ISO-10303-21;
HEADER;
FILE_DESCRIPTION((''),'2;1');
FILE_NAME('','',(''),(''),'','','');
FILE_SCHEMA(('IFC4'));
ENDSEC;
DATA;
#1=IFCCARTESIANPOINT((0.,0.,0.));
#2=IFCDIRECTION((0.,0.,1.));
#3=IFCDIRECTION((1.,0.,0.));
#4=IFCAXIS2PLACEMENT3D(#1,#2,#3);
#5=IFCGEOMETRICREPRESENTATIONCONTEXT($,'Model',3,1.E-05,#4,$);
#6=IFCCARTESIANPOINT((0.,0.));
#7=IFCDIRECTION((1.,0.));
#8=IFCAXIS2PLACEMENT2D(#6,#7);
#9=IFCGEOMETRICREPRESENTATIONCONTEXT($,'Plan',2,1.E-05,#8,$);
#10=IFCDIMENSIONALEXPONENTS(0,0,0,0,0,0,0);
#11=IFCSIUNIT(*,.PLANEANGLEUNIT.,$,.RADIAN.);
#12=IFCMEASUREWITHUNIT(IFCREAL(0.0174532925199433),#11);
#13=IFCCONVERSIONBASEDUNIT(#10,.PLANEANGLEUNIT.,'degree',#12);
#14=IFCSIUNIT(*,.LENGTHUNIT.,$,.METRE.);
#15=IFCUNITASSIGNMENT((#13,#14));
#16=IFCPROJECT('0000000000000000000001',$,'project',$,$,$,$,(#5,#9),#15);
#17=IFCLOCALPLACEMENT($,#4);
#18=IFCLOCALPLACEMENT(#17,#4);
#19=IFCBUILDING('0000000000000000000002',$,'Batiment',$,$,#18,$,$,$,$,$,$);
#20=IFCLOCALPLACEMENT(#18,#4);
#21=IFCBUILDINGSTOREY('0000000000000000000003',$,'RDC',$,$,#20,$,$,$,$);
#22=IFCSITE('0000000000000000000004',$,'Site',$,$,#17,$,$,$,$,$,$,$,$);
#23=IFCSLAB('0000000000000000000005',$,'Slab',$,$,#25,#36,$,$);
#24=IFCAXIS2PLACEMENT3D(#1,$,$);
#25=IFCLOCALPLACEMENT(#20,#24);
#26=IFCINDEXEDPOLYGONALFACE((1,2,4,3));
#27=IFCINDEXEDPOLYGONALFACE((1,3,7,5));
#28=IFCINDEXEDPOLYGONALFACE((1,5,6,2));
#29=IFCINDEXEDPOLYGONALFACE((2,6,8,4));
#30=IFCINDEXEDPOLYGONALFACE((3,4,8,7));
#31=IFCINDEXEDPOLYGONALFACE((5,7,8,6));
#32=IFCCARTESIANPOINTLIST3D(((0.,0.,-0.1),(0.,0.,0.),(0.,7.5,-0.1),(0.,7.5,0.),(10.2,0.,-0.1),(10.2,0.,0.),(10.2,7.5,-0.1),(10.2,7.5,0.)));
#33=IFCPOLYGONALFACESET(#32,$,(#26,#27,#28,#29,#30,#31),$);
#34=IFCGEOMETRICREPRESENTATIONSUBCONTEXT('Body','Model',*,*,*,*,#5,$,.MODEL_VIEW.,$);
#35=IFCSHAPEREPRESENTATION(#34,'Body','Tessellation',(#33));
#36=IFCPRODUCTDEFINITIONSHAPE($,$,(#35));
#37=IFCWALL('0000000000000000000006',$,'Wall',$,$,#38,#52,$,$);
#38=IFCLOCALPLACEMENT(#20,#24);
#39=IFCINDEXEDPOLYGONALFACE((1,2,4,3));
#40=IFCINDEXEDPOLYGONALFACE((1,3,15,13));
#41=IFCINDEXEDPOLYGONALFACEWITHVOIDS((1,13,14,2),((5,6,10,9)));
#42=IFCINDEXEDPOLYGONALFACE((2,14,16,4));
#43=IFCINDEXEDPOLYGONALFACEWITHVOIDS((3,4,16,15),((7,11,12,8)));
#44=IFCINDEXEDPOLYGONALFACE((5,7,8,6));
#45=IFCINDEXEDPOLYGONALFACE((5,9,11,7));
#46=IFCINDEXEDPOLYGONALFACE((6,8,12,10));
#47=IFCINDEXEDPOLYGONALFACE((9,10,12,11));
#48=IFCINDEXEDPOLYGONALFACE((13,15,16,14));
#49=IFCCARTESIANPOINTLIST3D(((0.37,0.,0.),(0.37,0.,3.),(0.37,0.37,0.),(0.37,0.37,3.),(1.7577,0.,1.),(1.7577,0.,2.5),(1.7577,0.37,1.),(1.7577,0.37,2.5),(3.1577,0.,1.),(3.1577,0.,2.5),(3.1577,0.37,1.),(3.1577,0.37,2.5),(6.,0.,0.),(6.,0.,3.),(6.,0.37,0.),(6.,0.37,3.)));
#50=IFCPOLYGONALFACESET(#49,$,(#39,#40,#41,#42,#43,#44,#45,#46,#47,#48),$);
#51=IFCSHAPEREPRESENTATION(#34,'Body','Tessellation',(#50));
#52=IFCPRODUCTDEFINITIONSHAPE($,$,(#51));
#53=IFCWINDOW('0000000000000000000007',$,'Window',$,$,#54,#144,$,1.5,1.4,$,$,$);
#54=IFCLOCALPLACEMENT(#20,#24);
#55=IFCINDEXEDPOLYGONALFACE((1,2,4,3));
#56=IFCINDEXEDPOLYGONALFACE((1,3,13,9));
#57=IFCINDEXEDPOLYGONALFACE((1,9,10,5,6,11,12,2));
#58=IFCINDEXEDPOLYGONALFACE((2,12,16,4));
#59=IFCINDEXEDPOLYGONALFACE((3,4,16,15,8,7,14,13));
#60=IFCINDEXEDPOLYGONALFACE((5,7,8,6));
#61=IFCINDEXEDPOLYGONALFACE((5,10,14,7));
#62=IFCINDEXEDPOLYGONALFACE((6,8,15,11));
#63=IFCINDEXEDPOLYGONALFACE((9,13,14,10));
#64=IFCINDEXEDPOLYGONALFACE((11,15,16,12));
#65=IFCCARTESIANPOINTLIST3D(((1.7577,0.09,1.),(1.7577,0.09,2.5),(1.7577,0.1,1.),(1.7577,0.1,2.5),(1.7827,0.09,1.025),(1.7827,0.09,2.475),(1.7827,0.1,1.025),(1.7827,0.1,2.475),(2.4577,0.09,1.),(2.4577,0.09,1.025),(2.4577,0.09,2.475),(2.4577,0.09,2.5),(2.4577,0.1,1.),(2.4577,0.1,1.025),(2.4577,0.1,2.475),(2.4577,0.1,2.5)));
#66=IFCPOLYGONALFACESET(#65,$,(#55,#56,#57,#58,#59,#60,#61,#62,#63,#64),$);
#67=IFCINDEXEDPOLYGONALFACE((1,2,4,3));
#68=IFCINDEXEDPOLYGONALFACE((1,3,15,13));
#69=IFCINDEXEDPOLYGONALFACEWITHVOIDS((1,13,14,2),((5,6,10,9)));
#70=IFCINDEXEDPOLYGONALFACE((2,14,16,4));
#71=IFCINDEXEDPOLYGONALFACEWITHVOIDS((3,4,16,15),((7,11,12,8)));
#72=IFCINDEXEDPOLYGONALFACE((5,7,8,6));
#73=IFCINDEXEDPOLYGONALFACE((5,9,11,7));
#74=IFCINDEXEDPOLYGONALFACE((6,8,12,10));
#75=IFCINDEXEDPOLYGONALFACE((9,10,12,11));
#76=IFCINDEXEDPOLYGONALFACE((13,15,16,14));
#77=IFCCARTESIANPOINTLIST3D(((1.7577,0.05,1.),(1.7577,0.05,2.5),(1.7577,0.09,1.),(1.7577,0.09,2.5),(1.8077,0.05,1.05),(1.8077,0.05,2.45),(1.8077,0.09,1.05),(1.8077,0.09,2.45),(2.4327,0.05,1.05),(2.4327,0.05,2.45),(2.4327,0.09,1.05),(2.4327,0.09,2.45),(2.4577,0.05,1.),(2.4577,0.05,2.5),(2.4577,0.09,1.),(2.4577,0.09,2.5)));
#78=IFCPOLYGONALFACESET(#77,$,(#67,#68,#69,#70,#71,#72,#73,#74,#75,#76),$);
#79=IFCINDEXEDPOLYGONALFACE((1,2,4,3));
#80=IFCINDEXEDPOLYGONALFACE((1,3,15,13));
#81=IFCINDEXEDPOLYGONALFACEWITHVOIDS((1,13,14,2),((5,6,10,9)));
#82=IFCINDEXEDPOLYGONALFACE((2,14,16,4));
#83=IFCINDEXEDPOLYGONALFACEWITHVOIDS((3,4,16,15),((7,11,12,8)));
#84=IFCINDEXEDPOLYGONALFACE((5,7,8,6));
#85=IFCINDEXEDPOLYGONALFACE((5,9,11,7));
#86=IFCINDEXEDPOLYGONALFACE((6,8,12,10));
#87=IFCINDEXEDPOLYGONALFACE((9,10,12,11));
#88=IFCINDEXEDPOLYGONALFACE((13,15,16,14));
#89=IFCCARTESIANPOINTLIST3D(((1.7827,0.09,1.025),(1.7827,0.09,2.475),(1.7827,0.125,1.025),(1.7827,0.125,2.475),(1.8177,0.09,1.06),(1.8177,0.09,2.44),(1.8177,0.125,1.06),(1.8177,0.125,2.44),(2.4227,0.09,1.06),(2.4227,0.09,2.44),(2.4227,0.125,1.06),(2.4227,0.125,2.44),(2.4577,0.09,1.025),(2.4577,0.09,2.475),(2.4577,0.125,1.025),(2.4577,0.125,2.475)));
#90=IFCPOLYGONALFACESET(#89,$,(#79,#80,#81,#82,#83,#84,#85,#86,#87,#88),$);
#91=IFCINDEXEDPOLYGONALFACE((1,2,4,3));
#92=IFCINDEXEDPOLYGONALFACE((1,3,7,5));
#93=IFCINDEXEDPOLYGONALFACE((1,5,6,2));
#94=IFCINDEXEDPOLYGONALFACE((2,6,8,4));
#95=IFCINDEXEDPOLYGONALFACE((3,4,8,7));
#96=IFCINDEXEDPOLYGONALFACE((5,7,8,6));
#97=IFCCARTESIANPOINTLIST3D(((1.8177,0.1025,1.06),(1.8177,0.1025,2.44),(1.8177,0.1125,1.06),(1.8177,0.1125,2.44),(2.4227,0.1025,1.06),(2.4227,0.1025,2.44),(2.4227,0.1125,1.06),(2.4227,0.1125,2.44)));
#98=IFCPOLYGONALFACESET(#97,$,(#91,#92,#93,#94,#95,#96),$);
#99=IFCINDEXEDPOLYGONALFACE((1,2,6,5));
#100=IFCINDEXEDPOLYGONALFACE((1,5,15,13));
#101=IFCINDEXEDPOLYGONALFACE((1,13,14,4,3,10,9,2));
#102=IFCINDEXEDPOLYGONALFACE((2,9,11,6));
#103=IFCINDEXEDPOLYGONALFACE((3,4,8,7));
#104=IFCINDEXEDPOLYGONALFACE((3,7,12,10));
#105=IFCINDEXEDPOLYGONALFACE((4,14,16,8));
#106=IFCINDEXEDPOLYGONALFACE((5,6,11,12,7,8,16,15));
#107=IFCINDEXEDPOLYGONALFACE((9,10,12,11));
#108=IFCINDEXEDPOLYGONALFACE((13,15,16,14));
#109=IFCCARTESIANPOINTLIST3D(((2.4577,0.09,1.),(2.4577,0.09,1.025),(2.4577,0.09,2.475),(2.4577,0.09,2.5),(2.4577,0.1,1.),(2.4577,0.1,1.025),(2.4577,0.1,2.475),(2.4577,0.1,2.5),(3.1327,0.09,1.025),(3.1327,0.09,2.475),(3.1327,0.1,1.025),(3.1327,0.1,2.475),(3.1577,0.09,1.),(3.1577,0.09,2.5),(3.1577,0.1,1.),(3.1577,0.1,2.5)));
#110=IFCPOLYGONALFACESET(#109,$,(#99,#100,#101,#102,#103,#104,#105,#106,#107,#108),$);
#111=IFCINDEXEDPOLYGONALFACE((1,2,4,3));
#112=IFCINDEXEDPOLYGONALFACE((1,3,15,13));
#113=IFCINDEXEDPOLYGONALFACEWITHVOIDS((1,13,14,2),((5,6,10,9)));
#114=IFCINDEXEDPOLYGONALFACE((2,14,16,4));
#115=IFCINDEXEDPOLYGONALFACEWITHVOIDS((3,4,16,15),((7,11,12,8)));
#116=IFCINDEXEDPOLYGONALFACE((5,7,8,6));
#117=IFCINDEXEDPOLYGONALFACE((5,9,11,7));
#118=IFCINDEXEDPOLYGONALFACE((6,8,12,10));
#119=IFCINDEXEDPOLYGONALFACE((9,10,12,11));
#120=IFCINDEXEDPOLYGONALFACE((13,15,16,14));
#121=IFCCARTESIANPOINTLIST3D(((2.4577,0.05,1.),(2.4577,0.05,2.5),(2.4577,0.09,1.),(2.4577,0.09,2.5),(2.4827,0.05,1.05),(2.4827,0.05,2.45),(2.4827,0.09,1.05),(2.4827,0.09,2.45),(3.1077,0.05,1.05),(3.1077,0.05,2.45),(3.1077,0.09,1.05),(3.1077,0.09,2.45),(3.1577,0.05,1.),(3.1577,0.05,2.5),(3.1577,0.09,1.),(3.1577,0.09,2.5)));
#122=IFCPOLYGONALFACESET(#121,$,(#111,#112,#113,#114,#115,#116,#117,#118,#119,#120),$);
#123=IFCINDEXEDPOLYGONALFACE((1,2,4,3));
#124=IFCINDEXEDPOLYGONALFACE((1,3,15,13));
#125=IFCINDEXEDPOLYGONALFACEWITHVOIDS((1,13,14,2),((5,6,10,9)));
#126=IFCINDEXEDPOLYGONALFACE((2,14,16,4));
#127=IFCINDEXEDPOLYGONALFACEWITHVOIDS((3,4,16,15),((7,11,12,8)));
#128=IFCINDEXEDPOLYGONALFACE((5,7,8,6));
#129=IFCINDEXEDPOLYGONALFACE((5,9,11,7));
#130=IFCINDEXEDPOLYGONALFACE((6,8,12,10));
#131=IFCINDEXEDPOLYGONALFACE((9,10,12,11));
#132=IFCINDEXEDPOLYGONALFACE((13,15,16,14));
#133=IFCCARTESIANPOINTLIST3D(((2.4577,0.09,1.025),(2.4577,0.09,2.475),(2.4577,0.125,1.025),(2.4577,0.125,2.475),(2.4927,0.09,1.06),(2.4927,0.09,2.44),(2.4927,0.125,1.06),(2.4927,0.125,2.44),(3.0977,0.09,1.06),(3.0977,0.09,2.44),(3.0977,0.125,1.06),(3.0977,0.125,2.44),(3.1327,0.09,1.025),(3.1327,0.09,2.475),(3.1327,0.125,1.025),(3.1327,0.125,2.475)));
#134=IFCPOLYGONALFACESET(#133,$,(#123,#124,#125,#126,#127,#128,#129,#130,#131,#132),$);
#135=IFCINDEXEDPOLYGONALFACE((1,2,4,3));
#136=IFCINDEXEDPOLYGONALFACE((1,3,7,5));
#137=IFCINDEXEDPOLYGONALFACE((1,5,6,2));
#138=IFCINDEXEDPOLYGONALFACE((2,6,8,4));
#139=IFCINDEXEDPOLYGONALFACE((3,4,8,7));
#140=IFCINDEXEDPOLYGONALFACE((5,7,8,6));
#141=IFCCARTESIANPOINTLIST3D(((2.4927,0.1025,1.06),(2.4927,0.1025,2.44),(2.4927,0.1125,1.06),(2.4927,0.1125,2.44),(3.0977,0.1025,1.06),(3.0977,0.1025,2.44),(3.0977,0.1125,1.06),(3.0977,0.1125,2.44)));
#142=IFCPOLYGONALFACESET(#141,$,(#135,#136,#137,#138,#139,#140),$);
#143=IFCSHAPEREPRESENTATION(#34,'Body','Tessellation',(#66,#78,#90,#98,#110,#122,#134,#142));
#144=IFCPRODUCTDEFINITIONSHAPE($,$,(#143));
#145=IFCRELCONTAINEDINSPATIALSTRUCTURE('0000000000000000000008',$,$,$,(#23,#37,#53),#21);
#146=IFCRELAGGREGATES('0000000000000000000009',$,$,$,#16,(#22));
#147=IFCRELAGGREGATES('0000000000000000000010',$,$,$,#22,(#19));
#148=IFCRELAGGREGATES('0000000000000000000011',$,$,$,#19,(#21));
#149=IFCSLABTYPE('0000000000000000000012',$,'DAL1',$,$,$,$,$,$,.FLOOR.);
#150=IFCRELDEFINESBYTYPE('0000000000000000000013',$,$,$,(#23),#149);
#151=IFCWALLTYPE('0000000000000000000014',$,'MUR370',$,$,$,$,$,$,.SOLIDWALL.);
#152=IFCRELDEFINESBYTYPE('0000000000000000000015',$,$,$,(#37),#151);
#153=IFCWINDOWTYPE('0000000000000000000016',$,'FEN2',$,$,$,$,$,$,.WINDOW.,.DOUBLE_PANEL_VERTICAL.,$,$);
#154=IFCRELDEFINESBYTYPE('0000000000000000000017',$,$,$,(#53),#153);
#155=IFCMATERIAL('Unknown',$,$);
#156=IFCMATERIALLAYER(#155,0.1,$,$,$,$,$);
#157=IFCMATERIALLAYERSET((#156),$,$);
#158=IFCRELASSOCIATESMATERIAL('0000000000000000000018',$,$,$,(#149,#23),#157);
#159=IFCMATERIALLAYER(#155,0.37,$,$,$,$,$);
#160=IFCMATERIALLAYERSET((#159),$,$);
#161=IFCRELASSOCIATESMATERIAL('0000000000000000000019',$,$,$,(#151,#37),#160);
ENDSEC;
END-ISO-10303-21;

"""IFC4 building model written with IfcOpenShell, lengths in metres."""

from ifc_helpers import new_model, entity, si_unit, converted_unit, frame, origin_with_axes, origin_2d_with_axis, place, context, subcontext, project, spatial, line, indexed_curve, outline, extrude, shape, source, transform, mapped, material, layer, layer_set, layer_usage, type_object, type_shapes, element, fill, save


model = new_model("IFC4")

# Units and contexts
model_context = context("Model", 3, precision=1e-05, world=origin_with_axes())
plan_context = context("Plan", 2, precision=1e-05, world=origin_2d_with_axis())
body_context_1 = subcontext(model_context, "Body", "Model", "MODEL_VIEW")
body_context_2 = subcontext(plan_context, "Body", "Plan", "PLAN_VIEW")
ifc_project = project(units=[converted_unit("PLANEANGLEUNIT", "degree", entity("IfcReal", 0.0174532925199433), si_unit("PLANEANGLEUNIT", "RADIAN"), dimensions=[0, 0, 0, 0, 0, 0, 0]), si_unit("LENGTHUNIT", "METRE")], contexts=[model_context, plan_context])

# Site, building, storey
site_placement = place(None, origin_with_axes())
site = spatial("IfcSite", under=ifc_project, at=site_placement, Name="Site")
building_placement = place(site_placement, origin_with_axes())
building = spatial("IfcBuilding", under=site, at=building_placement, Name="Batiment")
storey_placement = place(building_placement, origin_with_axes())
storey = spatial("IfcBuildingStorey", under=building, at=storey_placement, Name="RDC")

# Slab
ifc_material = material(Name="Unknown")
ifc_layer_1 = layer(ifc_material, 0.1)
ifc_layer_set_1 = layer_set([ifc_layer_1])
ifc_layer_usage_1 = layer_usage(ifc_layer_set_1, "AXIS3", "POSITIVE", 0.0)
slab_type = type_object("IfcSlabType", Name="DAL1", PredefinedType="FLOOR", material=ifc_layer_set_1)
slab_placement = place(storey_placement, frame((0.0, 0.0, -0.1), z_axis=(0.0, 0.0, 1.0), x_axis=(1.0, 0.0, 0.0)))
element("IfcSlab", 1, at=slab_placement, inside=storey, type_object=slab_type, material=ifc_layer_usage_1, Name="Slab", context=body_context_1, shape_type="SweptSolid", body=[
    extrude(outline(indexed_curve([(0.0, 0.0), (10.2, 0.0), (10.2, 7.5), (0.0, 7.5)], segments=[line(4, 1), line(1, 2), line(2, 3), line(3, 4)], self_intersect=False)), None, (0.0, 0.0, 1.0), 0.1),
])

# Wall, opening, window
ifc_layer_2 = layer(ifc_material, 0.37)
ifc_layer_set_2 = layer_set([ifc_layer_2])
ifc_layer_usage_2 = layer_usage(ifc_layer_set_2, "AXIS2", "POSITIVE", 0.0)
wall_type_1 = type_object("IfcWallType", Name="MUR370", PredefinedType="SOLIDWALL", material=ifc_layer_set_2)
wall_1_placement = place(storey_placement, frame((0.37, 0.0, 0.0), z_axis=(0.0, 0.0, 1.0), x_axis=(1.0, 0.0, 0.0)))
wall_1 = element("IfcWall", 2, at=wall_1_placement, inside=storey, type_object=wall_type_1, material=ifc_layer_usage_2, Name="Wall", context=body_context_1, shape_type="SweptSolid", body=[
    extrude(outline(indexed_curve([(0.0, 0.0), (0.0, 0.37), (5.63, 0.37), (5.63, 0.0), (0.0, 0.0)], self_intersect=False)), origin_with_axes(), (0.0, 0.0, 1.0), 3.0),
])
shared_shape_1 = source(origin_with_axes(), body_context_1, "Body", "SweptSolid", [
    extrude(outline(indexed_curve([(0.0, 0.0), (1.4, 0.0), (1.4, 1.5), (0.0, 1.5)], segments=[line(1, 2, 3, 4, 1)])), frame((0.0, -0.6, 0.0), z_axis=(0.0, -1.0, 0.0), x_axis=(1.0, 0.0, 0.0)), (0.0, 0.0, -1.0), 1.2),
])
opening_1_placement = place(wall_1_placement, frame((1.3877, 0.0, 1.0), z_axis=(0.0, 0.0, 1.0), x_axis=(1.0, 0.0, 0.0)))
opening_1 = element("IfcOpeningElement", 3, at=opening_1_placement, cuts=wall_1, PredefinedType="OPENING", context=body_context_1, shape_type="MappedRepresentation", body=[
    mapped(shared_shape_1, transform((0.0, 0.0, 0.0), x_axis=(1.0, 0.0, 0.0), y_axis=(0.0, 1.0, 0.0), z_axis=(0.0, 0.0, 1.0), scale=1.0)),
])
window_type_1 = type_object("IfcWindowType", Name="FEN2", PartitioningType="DOUBLE_PANEL_VERTICAL", PredefinedType="WINDOW")
shared_shape_2 = source(origin_with_axes(), body_context_1, "Body", "SweptSolid", [
    extrude(outline(indexed_curve([(0.7, 0.0), (0.0, 0.0), (0.0, 1.5), (0.7, 1.5), (0.7, 1.475), (0.025, 1.475), (0.025, 0.025), (0.7, 0.025)], segments=[line(1, 2, 3, 4, 5, 6, 7, 8, 1)])), frame((0.0, 0.09, 0.0), z_axis=(0.0, -1.0, 0.0), x_axis=(1.0, 0.0, 0.0)), (0.0, 0.0, -1.0), 0.01),
    extrude(outline(indexed_curve([(0.0, 0.0), (0.7, 0.0), (0.7, 1.5), (0.0, 1.5)], segments=[line(1, 2, 3, 4, 1)]), holes=[indexed_curve([(0.05, 0.05), (0.675, 0.05), (0.675, 1.45), (0.05, 1.45)], segments=[line(1, 2, 3, 4, 1)])]), frame((0.0, 0.05, 0.0), z_axis=(0.0, -1.0, 0.0), x_axis=(1.0, 0.0, 0.0)), (0.0, 0.0, -1.0), 0.04),
    extrude(outline(indexed_curve([(0.0, 0.0), (0.675, 0.0), (0.675, 1.45), (0.0, 1.45)], segments=[line(1, 2, 3, 4, 1)]), holes=[indexed_curve([(0.035, 0.035), (0.64, 0.035), (0.64, 1.415), (0.035, 1.415)], segments=[line(1, 2, 3, 4, 1)])]), frame((0.025, 0.09, 0.025), z_axis=(0.0, -1.0, 0.0), x_axis=(1.0, 0.0, 0.0)), (0.0, 0.0, -1.0), 0.035),
    extrude(outline(indexed_curve([(0.035, 0.035), (0.64, 0.035), (0.64, 1.415), (0.035, 1.415)], segments=[line(1, 2, 3, 4, 1)])), frame((0.025, 0.1025, 0.025), z_axis=(0.0, -1.0, 0.0), x_axis=(1.0, 0.0, 0.0)), (0.0, 0.0, -1.0), 0.01),
    extrude(outline(indexed_curve([(0.0, 1.5), (0.7, 1.5), (0.7, 0.0), (0.0, 0.0), (0.0, 0.025), (0.675, 0.025), (0.675, 1.475), (0.0, 1.475)], segments=[line(1, 2, 3, 4, 5, 6, 7, 8, 1)])), frame((0.7, 0.09, 0.0), z_axis=(0.0, -1.0, 0.0), x_axis=(1.0, 0.0, 0.0)), (0.0, 0.0, -1.0), 0.01),
    extrude(outline(indexed_curve([(0.0, 0.0), (0.7, 0.0), (0.7, 1.5), (0.0, 1.5)], segments=[line(1, 2, 3, 4, 1)]), holes=[indexed_curve([(0.025, 0.05), (0.65, 0.05), (0.65, 1.45), (0.025, 1.45)], segments=[line(1, 2, 3, 4, 1)])]), frame((0.7, 0.05, 0.0), z_axis=(0.0, -1.0, 0.0), x_axis=(1.0, 0.0, 0.0)), (0.0, 0.0, -1.0), 0.04),
    extrude(outline(indexed_curve([(0.0, 0.0), (0.675, 0.0), (0.675, 1.45), (0.0, 1.45)], segments=[line(1, 2, 3, 4, 1)]), holes=[indexed_curve([(0.035, 0.035), (0.64, 0.035), (0.64, 1.415), (0.035, 1.415)], segments=[line(1, 2, 3, 4, 1)])]), frame((0.7, 0.09, 0.025), z_axis=(0.0, -1.0, 0.0), x_axis=(1.0, 0.0, 0.0)), (0.0, 0.0, -1.0), 0.035),
    extrude(outline(indexed_curve([(0.035, 0.035), (0.64, 0.035), (0.64, 1.415), (0.035, 1.415)], segments=[line(1, 2, 3, 4, 1)])), frame((0.7, 0.1025, 0.025), z_axis=(0.0, -1.0, 0.0), x_axis=(1.0, 0.0, 0.0)), (0.0, 0.0, -1.0), 0.01),
])
shared_shape_3 = source(origin_with_axes(), body_context_2, "Body", "Curve2D", [
    entity("IfcIndexedPolyCurve", entity("IfcCartesianPointList2D", [[0.05, 0.05], [0.675, 0.05]])),
    entity("IfcIndexedPolyCurve", entity("IfcCartesianPointList2D", [[0.0, 0.1], [0.025, 0.1], [0.025, 0.09], [0.05, 0.09], [0.05, 0.05], [0.0, 0.05]]), [entity("IfcLineIndex", [1, 2, 3, 4, 5, 6, 1])]),
    entity("IfcIndexedPolyCurve", entity("IfcCartesianPointList2D", [[0.7, 0.1], [0.7, 0.1], [0.7, 0.09], [0.675, 0.09], [0.675, 0.05], [0.7, 0.05]])),
    entity("IfcIndexedPolyCurve", entity("IfcCartesianPointList2D", [[0.025, 0.09], [0.06, 0.09], [0.06, 0.125], [0.025, 0.125]]), [entity("IfcLineIndex", [1, 2, 3, 4, 1])]),
    entity("IfcIndexedPolyCurve", entity("IfcCartesianPointList2D", [[0.7, 0.09], [0.665, 0.09], [0.665, 0.125], [0.7, 0.125]]), [entity("IfcLineIndex", [1, 2, 3, 4, 1])]),
    entity("IfcIndexedPolyCurve", entity("IfcCartesianPointList2D", [[0.06, 0.09], [0.665, 0.09]])),
    entity("IfcIndexedPolyCurve", entity("IfcCartesianPointList2D", [[0.06, 0.125], [0.665, 0.125]])),
    entity("IfcIndexedPolyCurve", entity("IfcCartesianPointList2D", [[0.06, 0.1075], [0.665, 0.1075]])),
    entity("IfcIndexedPolyCurve", entity("IfcCartesianPointList2D", [[0.725, 0.05], [1.35, 0.05]])),
    entity("IfcIndexedPolyCurve", entity("IfcCartesianPointList2D", [[0.7, 0.1], [0.7, 0.1], [0.7, 0.09], [0.725, 0.09], [0.725, 0.05], [0.7, 0.05]])),
    entity("IfcIndexedPolyCurve", entity("IfcCartesianPointList2D", [[1.4, 0.1], [1.375, 0.1], [1.375, 0.09], [1.35, 0.09], [1.35, 0.05], [1.4, 0.05]]), [entity("IfcLineIndex", [1, 2, 3, 4, 5, 6, 1])]),
    entity("IfcIndexedPolyCurve", entity("IfcCartesianPointList2D", [[0.7, 0.09], [0.735, 0.09], [0.735, 0.125], [0.7, 0.125]]), [entity("IfcLineIndex", [1, 2, 3, 4, 1])]),
    entity("IfcIndexedPolyCurve", entity("IfcCartesianPointList2D", [[1.375, 0.09], [1.34, 0.09], [1.34, 0.125], [1.375, 0.125]]), [entity("IfcLineIndex", [1, 2, 3, 4, 1])]),
    entity("IfcIndexedPolyCurve", entity("IfcCartesianPointList2D", [[0.735, 0.09], [1.34, 0.09]])),
    entity("IfcIndexedPolyCurve", entity("IfcCartesianPointList2D", [[0.735, 0.125], [1.34, 0.125]])),
    entity("IfcIndexedPolyCurve", entity("IfcCartesianPointList2D", [[0.735, 0.1075], [1.34, 0.1075]])),
])
type_shapes(window_type_1, [shared_shape_2, shared_shape_3])
window_1_placement = place(opening_1_placement, origin_with_axes())
window_1 = element("IfcWindow", 4, at=window_1_placement, inside=storey, type_object=window_type_1, Name="Window", OverallHeight=1.5, OverallWidth=1.4, shapes=[
    shape(body_context_1, "Body", "MappedRepresentation", [mapped(shared_shape_2, transform((0.0, 0.0, 0.0), x_axis=(1.0, 0.0, 0.0), y_axis=(0.0, 1.0, 0.0), z_axis=(0.0, 0.0, 1.0), scale=1.0))]),
    shape(body_context_2, "Body", "MappedRepresentation", [mapped(shared_shape_3, transform((0.0, 0.0, 0.0), x_axis=(1.0, 0.0, 0.0), y_axis=(0.0, 1.0, 0.0), z_axis=(0.0, 0.0, 1.0), scale=1.0))]),
])
fill(opening_1, window_1)

save(model, "model.ifc")
